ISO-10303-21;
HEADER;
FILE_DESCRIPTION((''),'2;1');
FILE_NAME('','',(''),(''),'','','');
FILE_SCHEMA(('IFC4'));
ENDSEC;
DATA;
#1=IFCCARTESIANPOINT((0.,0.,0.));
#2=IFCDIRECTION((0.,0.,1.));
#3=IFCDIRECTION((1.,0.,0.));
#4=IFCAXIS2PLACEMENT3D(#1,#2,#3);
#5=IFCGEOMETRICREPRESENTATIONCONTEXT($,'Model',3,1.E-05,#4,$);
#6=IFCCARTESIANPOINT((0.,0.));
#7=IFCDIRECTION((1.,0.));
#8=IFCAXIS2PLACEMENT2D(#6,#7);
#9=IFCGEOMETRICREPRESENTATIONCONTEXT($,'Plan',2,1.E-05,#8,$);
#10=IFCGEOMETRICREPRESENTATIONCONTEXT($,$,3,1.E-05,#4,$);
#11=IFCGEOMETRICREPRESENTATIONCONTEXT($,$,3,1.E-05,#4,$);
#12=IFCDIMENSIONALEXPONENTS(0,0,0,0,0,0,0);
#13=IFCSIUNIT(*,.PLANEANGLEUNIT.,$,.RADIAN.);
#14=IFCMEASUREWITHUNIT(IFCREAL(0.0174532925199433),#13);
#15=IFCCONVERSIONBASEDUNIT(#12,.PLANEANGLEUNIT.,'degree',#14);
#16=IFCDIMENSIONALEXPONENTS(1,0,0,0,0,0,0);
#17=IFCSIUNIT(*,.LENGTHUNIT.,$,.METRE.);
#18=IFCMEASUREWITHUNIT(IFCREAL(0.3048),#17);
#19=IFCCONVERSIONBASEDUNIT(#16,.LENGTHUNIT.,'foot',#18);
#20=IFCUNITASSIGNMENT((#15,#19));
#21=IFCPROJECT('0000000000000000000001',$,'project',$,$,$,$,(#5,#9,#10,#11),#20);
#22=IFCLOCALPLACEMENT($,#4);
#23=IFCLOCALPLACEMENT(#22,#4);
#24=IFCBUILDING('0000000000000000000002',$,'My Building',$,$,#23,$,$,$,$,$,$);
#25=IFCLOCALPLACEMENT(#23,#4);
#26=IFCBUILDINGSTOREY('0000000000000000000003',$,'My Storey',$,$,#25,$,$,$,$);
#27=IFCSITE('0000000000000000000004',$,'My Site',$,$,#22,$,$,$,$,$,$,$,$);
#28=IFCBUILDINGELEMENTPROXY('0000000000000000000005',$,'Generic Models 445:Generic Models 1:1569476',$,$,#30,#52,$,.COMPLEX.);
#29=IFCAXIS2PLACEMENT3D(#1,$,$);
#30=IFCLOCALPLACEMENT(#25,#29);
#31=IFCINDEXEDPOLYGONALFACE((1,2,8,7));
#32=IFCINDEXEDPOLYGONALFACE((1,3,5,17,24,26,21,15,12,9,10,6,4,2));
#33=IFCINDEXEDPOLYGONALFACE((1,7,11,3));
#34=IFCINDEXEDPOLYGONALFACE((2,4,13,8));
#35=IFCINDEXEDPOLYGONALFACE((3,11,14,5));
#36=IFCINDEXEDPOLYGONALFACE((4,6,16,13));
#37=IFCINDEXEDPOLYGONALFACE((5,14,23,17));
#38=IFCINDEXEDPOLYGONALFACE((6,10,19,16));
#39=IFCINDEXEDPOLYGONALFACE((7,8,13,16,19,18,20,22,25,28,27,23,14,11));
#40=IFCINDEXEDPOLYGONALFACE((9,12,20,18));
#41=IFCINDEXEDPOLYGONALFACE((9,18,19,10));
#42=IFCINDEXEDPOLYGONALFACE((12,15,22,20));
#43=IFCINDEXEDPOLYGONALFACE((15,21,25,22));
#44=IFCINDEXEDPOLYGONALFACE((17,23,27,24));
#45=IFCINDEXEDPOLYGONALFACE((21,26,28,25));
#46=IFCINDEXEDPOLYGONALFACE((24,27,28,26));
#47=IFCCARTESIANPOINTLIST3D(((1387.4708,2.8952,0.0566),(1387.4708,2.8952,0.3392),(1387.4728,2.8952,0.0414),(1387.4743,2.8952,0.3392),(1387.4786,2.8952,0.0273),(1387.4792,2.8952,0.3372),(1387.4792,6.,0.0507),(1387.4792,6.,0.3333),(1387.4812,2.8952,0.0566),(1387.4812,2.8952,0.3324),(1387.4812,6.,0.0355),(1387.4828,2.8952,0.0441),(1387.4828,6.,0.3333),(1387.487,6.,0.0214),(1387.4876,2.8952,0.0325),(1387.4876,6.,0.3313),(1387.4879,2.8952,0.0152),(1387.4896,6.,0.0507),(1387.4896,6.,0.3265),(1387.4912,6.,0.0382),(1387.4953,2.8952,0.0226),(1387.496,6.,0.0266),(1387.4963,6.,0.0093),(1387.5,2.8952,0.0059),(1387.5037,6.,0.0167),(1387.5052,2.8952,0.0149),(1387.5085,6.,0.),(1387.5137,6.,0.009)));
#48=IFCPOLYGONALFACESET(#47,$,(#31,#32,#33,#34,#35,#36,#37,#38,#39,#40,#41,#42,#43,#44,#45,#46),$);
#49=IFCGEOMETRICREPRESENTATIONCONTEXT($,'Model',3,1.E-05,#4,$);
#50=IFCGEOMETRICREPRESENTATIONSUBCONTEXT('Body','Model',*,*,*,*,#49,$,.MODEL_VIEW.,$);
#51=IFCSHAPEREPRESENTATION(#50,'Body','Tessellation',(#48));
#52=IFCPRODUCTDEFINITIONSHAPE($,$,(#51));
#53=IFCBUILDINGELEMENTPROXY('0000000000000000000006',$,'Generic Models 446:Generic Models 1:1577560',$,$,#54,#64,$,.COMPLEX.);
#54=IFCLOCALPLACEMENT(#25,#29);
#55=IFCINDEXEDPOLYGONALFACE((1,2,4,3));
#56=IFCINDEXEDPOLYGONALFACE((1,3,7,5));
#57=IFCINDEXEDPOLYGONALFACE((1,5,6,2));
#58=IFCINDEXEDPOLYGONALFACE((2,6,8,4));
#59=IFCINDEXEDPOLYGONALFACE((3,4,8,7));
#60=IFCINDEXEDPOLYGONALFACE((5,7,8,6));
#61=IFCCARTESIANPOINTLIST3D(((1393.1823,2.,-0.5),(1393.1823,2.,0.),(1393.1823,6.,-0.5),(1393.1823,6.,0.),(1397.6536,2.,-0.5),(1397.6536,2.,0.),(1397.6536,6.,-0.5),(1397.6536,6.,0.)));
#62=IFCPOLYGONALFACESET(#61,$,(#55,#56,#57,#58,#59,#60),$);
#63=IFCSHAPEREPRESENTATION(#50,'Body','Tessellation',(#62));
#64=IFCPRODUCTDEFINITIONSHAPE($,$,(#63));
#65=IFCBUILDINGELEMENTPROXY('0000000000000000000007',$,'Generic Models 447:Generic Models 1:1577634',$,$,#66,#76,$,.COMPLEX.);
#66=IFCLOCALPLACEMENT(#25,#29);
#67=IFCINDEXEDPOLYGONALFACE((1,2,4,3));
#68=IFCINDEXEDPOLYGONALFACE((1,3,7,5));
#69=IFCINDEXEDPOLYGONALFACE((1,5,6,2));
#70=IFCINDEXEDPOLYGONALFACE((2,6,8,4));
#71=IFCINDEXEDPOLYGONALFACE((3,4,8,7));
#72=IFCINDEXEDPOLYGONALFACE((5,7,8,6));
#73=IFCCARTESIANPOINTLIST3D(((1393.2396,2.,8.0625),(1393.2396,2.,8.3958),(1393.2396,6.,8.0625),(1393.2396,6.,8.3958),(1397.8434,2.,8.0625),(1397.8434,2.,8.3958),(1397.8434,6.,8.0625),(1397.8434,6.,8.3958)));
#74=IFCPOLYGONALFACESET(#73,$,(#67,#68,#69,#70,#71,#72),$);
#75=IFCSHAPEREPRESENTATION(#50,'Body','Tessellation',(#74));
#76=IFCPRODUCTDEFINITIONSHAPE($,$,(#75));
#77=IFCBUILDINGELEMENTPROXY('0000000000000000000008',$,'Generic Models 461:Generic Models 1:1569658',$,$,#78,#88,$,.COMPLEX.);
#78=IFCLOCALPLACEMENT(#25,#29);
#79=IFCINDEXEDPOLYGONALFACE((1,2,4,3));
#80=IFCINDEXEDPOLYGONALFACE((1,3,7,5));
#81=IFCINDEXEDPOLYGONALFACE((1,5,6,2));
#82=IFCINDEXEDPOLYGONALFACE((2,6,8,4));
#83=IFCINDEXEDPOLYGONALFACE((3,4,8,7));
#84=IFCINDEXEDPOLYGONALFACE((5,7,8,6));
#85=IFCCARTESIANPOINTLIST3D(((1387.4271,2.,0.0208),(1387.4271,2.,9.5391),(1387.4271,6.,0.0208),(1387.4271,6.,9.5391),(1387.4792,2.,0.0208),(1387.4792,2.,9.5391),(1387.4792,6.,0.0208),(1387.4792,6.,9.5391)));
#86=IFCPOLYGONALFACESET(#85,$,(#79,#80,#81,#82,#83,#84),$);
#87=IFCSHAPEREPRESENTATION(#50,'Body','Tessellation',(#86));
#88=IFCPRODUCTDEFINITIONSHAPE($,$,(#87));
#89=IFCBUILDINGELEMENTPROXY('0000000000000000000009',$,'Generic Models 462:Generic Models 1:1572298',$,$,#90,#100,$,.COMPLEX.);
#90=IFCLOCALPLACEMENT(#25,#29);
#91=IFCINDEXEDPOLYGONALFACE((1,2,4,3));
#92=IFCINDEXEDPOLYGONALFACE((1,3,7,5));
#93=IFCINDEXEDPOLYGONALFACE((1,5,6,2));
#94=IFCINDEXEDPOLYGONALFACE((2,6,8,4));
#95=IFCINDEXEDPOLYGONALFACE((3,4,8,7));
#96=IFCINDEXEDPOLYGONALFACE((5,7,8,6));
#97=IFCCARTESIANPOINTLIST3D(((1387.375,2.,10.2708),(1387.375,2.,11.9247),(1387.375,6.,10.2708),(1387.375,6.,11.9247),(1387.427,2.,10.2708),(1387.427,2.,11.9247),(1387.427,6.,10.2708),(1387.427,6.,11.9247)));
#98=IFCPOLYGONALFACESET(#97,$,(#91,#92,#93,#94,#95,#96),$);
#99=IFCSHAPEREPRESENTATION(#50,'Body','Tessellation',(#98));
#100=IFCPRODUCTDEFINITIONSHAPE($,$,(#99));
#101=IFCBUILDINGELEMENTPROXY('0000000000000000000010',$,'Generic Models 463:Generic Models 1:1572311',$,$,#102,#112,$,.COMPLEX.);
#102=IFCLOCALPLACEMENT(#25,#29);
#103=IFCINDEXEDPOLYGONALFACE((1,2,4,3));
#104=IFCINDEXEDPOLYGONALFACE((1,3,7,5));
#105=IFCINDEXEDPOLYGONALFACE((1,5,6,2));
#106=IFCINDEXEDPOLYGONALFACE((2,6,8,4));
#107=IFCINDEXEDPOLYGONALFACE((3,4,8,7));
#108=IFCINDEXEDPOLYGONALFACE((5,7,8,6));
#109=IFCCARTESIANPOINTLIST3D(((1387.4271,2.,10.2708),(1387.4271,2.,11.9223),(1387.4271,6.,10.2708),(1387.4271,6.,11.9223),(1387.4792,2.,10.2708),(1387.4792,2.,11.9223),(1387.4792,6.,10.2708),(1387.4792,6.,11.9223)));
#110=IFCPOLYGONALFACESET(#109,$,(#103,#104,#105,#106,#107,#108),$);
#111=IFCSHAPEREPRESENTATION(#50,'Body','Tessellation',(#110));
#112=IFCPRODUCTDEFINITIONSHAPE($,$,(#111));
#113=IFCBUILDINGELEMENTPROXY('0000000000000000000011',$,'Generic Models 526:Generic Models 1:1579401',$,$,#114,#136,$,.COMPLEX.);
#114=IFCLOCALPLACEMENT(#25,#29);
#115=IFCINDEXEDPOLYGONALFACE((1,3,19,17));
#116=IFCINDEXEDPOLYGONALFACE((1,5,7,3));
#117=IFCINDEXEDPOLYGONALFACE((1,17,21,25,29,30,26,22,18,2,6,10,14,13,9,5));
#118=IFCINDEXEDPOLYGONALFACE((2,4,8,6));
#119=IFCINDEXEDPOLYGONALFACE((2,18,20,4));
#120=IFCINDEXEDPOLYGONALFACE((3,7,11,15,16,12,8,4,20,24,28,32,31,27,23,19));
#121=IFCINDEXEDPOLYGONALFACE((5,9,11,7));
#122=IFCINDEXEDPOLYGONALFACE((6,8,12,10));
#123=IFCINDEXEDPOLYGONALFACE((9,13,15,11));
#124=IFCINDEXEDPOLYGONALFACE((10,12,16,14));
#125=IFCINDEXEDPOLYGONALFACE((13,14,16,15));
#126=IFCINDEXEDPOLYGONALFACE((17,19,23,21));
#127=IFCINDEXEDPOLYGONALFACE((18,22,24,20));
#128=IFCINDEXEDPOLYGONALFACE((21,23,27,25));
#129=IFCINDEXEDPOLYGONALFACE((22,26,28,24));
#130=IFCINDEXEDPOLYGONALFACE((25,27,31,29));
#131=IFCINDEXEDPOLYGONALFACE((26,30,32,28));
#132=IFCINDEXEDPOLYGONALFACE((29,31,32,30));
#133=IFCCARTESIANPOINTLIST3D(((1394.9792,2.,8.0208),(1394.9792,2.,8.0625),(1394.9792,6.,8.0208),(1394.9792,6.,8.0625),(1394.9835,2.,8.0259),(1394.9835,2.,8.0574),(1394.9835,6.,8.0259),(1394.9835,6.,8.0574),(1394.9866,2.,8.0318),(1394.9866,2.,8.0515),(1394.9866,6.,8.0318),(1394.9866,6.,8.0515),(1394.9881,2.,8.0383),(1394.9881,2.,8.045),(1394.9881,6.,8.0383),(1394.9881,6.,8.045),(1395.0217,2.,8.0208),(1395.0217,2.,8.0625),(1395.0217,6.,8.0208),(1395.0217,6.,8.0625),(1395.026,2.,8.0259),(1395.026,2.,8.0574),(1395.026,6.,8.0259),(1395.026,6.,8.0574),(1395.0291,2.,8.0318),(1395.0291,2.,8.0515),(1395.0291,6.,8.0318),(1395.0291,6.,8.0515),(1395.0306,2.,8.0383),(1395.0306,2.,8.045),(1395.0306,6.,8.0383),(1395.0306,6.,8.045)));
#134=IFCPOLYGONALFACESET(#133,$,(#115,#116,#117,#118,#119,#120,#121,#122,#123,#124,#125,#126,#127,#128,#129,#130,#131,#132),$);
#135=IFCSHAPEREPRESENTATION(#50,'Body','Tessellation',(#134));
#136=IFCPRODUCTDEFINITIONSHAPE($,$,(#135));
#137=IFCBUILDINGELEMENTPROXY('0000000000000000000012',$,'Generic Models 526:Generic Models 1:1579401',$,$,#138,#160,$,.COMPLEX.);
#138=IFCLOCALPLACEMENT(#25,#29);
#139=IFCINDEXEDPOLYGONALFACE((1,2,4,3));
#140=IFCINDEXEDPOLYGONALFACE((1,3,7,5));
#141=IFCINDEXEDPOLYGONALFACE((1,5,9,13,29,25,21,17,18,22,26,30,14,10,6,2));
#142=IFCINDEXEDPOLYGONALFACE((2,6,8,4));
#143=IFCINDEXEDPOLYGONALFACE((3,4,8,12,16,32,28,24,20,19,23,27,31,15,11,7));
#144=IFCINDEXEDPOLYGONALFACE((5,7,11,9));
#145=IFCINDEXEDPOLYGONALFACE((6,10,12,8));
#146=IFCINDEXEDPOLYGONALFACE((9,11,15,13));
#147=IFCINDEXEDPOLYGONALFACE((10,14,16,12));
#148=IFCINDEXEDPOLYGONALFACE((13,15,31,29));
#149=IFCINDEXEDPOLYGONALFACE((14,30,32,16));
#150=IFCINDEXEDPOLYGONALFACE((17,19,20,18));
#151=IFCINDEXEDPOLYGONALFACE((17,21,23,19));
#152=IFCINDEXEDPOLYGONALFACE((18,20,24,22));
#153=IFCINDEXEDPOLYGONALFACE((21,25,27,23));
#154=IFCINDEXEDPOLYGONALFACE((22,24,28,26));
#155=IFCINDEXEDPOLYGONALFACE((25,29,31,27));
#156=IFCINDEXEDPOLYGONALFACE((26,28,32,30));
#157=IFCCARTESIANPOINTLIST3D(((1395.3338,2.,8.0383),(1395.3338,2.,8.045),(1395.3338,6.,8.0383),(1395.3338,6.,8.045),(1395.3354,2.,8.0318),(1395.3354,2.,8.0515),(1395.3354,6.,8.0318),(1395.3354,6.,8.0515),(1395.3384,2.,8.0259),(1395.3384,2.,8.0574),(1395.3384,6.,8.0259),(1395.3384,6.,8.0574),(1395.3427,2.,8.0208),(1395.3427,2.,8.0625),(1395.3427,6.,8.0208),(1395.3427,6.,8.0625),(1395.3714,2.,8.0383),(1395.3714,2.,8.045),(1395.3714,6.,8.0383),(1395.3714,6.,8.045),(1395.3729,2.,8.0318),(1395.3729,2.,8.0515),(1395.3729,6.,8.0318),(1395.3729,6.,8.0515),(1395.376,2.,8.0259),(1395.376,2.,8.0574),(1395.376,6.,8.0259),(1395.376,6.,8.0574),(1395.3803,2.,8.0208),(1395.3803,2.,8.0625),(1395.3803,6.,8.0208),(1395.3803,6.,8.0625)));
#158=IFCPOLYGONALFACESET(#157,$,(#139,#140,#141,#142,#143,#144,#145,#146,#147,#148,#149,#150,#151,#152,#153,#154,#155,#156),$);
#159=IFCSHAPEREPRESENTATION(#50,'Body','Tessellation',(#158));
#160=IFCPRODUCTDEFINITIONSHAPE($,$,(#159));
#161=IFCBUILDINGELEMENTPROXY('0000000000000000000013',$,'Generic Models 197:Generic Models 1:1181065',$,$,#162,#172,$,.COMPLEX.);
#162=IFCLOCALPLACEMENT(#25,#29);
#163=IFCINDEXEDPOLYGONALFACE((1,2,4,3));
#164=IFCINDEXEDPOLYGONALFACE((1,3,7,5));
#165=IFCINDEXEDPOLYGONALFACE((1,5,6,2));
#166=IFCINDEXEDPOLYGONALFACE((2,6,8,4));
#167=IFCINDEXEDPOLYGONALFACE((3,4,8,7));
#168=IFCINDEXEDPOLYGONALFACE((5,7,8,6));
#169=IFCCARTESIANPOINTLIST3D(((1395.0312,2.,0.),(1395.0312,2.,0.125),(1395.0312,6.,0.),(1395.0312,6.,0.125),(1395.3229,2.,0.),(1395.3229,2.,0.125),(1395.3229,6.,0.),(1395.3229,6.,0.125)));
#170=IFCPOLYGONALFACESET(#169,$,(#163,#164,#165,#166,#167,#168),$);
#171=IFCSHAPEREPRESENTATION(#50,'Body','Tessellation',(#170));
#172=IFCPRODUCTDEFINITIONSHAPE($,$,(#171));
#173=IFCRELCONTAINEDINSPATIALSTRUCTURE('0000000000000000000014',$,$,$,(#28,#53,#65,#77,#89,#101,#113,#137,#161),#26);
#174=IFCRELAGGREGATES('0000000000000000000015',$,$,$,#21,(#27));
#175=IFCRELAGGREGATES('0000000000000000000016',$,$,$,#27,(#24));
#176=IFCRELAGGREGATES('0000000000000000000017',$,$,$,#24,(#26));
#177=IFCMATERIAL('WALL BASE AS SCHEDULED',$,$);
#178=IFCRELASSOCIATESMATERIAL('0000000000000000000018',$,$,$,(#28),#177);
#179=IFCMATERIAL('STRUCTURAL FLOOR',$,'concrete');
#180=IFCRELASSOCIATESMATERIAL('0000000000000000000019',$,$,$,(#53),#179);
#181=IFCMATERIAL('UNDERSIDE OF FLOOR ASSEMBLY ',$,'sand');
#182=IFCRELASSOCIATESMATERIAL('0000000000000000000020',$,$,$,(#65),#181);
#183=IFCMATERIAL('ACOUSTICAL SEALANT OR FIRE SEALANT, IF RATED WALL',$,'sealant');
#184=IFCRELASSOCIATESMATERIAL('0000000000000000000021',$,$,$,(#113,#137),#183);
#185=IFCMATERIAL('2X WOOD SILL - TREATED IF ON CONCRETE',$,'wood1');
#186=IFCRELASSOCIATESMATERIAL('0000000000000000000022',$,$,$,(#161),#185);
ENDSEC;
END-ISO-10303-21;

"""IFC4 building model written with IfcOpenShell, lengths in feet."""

from ifc_helpers import new_model, entity, si_unit, converted_unit, frame, origin_with_axes, origin_2d_with_axis, place, context, subcontext, project, spatial, polyline, line, indexed_curve, outline, extrude, material, element, save


model = new_model("IFC4")

# Units and contexts
model_context_1 = context("Model", 3, precision=1e-05, world=origin_with_axes())
plan_context = context("Plan", 2, precision=1e-05, world=origin_2d_with_axis())
model_context_2 = context("Model", 3, precision=1e-05, world=origin_with_axes())
context_of_model_1 = context(None, 3, precision=1e-05, world=origin_with_axes())
context_of_model_2 = context(None, 3, precision=1e-05, world=origin_with_axes())
body_context_1 = subcontext(model_context_2, "Body", "Model", "MODEL_VIEW")
ifc_project = project(units=[converted_unit("PLANEANGLEUNIT", "degree", entity("IfcReal", 0.0174532925199433), si_unit("PLANEANGLEUNIT", "RADIAN"), dimensions=[0, 0, 0, 0, 0, 0, 0]), converted_unit("LENGTHUNIT", "foot", entity("IfcReal", 0.3048), si_unit("LENGTHUNIT", "METRE"), dimensions=[1, 0, 0, 0, 0, 0, 0])], contexts=[model_context_1, plan_context, context_of_model_1, context_of_model_2])

# Site, building, storey
site_placement = place(None, origin_with_axes())
site = spatial("IfcSite", under=ifc_project, at=site_placement, Name="My Site")
building_placement = place(site_placement, origin_with_axes())
building = spatial("IfcBuilding", under=site, at=building_placement, Name="My Building")
storey_placement = place(building_placement, origin_with_axes())
storey = spatial("IfcBuildingStorey", under=building, at=storey_placement, Name="My Storey")

# Building element proxies
ifc_material_1 = material(Name="WALL BASE AS SCHEDULED")
ifc_material_2 = material(Name="STRUCTURAL FLOOR", Category="concrete")
ifc_material_3 = material(Name="UNDERSIDE OF FLOOR ASSEMBLY ", Category="sand")
ifc_material_4 = material(Name="ACOUSTICAL SEALANT OR FIRE SEALANT, IF RATED WALL", Category="sealant")
proxy_1_placement = place(storey_placement, frame((1387.4792, 6.0, 0.0), z_axis=(0.0, -1.0, 0.0), x_axis=(0.0, 0.0, 1.0)))
element("IfcBuildingElementProxy", 1, at=proxy_1_placement, inside=storey, material=ifc_material_1, Name="Generic Models 445:Generic Models 1:1569476", PredefinedType="COMPLEX", context=body_context_1, shape_type="SweptSolid", body=[
    extrude(outline(polyline([(0.2206, 0.0), (0.2204, 0.0036), (0.2182, 0.0083), (0.2132, 0.01), (-0.0621, -0.0058), (-0.0747, -0.0049), (-0.0865, -0.0007), (-0.0969, 0.0063), (-0.1051, 0.0158), (-0.1138, 0.0101), (-0.1038, -0.0014), (-0.0912, -0.01), (-0.0768, -0.0151), (-0.0615, -0.0162), (0.2206, 0.0)])), frame((0.113, -0.0126, 0.0), z_axis=(0.0, 0.0, -1.0), x_axis=(0.998358, 0.057286, 0.0)), (0.002054, -0.002598, -0.999995), 3.1048),
])
proxy_2_placement = place(storey_placement, frame((1393.1823, 6.0, -0.5), z_axis=(0.0, -1.0, 0.0), x_axis=(0.0, 0.0, 1.0)))
element("IfcBuildingElementProxy", 2, at=proxy_2_placement, inside=storey, material=ifc_material_2, Name="Generic Models 446:Generic Models 1:1577560", PredefinedType="COMPLEX", context=body_context_1, shape_type="SweptSolid", body=[
    extrude(outline(indexed_curve([(-2.4713, -0.25), (2.0, -0.25), (2.0, 0.25), (-2.4713, 0.25)], segments=[line(4, 1), line(1, 2), line(2, 3), line(3, 4)], self_intersect=False)), frame((0.25, -2.0, 0.0), z_axis=(0.0, 0.0, -1.0), x_axis=(0.0, 1.0, 0.0)), (0.0, 0.0, -1.0), 4.0),
])
proxy_3_placement = place(storey_placement, frame((1393.2396, 6.0, 8.0625), z_axis=(0.0, -1.0, 0.0), x_axis=(0.0, 0.0, 1.0)))
element("IfcBuildingElementProxy", 3, at=proxy_3_placement, inside=storey, material=ifc_material_3, Name="Generic Models 447:Generic Models 1:1577634", PredefinedType="COMPLEX", context=body_context_1, shape_type="SweptSolid", body=[
    extrude(outline(indexed_curve([(2.0, -0.1667), (2.0, 0.1667), (-2.6038, 0.1667), (-2.6038, -0.1667)], segments=[line(3, 2), line(2, 1), line(1, 4), line(4, 3)], self_intersect=False)), frame((0.1667, -2.0, 0.0), z_axis=(0.0, 0.0, -1.0), x_axis=(0.0, 1.0, 0.0)), (0.0, 0.0, -1.0), 4.0),
])
proxy_4_placement = place(storey_placement, frame((1387.4271, 6.0, 0.0208), z_axis=(0.0, -1.0, 0.0), x_axis=(0.0, 0.0, 1.0)))
element("IfcBuildingElementProxy", 4, at=proxy_4_placement, inside=storey, Name="Generic Models 461:Generic Models 1:1569658", PredefinedType="COMPLEX", context=body_context_1, shape_type="SweptSolid", body=[
    extrude(outline(polyline([(-4.7591, -0.026), (4.7591, -0.026), (4.7591, 0.026), (-4.7591, 0.026), (-4.7591, -0.026)])), frame((4.7591, -0.026, 0.0), z_axis=(0.0, 0.0, -1.0), x_axis=(-1.0, 0.0, 0.0)), (0.0, 0.0, -1.0), 4.0),
])
proxy_5_placement = place(storey_placement, frame((1387.375, 6.0, 10.2708), z_axis=(0.0, -1.0, 0.0), x_axis=(0.0, 0.0, 1.0)))
element("IfcBuildingElementProxy", 5, at=proxy_5_placement, inside=storey, Name="Generic Models 462:Generic Models 1:1572298", PredefinedType="COMPLEX", context=body_context_1, shape_type="SweptSolid", body=[
    extrude(outline(polyline([(-0.026, -0.8269), (0.026, -0.8269), (0.026, 0.8269), (-0.026, 0.8269), (-0.026, -0.8269)])), frame((0.8269, -0.026, 0.0), z_axis=(0.0, 0.0, -1.0), x_axis=(0.0, 1.0, 0.0)), (0.0, 0.0, -1.0), 4.0),
])
proxy_6_placement = place(storey_placement, frame((1387.4271, 6.0, 10.2708), z_axis=(0.0, -1.0, 0.0), x_axis=(0.0, 0.0, 1.0)))
element("IfcBuildingElementProxy", 6, at=proxy_6_placement, inside=storey, Name="Generic Models 463:Generic Models 1:1572311", PredefinedType="COMPLEX", context=body_context_1, shape_type="SweptSolid", body=[
    extrude(outline(polyline([(-0.026, -0.8258), (0.026, -0.8258), (0.026, 0.8258), (-0.026, 0.8258), (-0.026, -0.8258)])), frame((0.8258, -0.026, 0.0), z_axis=(0.0, 0.0, -1.0), x_axis=(0.0, 1.0, 0.0)), (0.0, 0.0, -1.0), 4.0),
])
proxy_7_placement = place(storey_placement, frame((1394.9791, 6.0, 8.0208), z_axis=(0.0, -1.0, 0.0), x_axis=(0.0, 0.0, 1.0)))
element("IfcBuildingElementProxy", 7, at=proxy_7_placement, inside=storey, material=ifc_material_4, Name="Generic Models 526:Generic Models 1:1579401", PredefinedType="COMPLEX", context=body_context_1, shape_type="SweptSolid", body=[
    extrude(outline(indexed_curve([(0.0293, -0.0082), (0.0301, -0.0016), (0.001, 0.0294), (0.0002, 0.0228), (-0.002, 0.0165), (-0.0057, 0.0109), (-0.0105, 0.0064), (-0.0163, 0.0031), (-0.0228, 0.0012), (-0.0294, 0.0009), (-0.0003, -0.0301), (0.0063, -0.0298), (0.0128, -0.028), (0.0186, -0.0247), (0.0234, -0.0201), (0.0271, -0.0145)], segments=[line(2, 1), line(1, 16), line(16, 15), line(15, 14), line(14, 13), line(13, 12), line(12, 11), line(11, 10), line(10, 9), line(9, 8), line(8, 7), line(7, 6), line(6, 5), line(5, 4), line(4, 3), line(3, 2)], self_intersect=False)), frame((0.0208, -0.0208, 0.0), z_axis=(0.0, 0.0, -1.0), x_axis=(-0.729168, -0.684334, 0.0)), (0.0, 0.0, -1.0), 4.0),
])
proxy_8_placement = place(storey_placement, frame((1395.3854, 6.0, 8.0625), z_axis=(0.0, -1.0, 0.0), x_axis=(0.0, 0.0, -1.0)))
element("IfcBuildingElementProxy", 8, at=proxy_8_placement, inside=storey, material=ifc_material_4, Name="Generic Models 526:Generic Models 1:1579401", PredefinedType="COMPLEX", context=body_context_1, shape_type="SweptSolid", body=[
    extrude(outline(indexed_curve([(-0.0193, -0.0025), (-0.0129, -0.0006), (-0.0071, 0.0027), (-0.0022, 0.0072), (0.0014, 0.0128), (0.0037, 0.0191), (0.0044, 0.0258), (0.0301, -0.0017), (0.0294, -0.0083), (0.0272, -0.0146), (0.0235, -0.0202), (0.0186, -0.0247), (0.0128, -0.028), (0.0064, -0.0299), (-0.0002, -0.0302), (-0.026, -0.0028)], segments=[line(2, 1), line(1, 16), line(16, 15), line(15, 14), line(14, 13), line(13, 12), line(12, 11), line(11, 10), line(10, 9), line(9, 8), line(8, 7), line(7, 6), line(6, 5), line(5, 4), line(4, 3), line(3, 2)], self_intersect=False)), frame((0.0208, -0.0208, 0.0), z_axis=(0.0, 0.0, -1.0), x_axis=(-0.729168, -0.684334, 0.0)), (0.0, 0.0, -1.0), 4.0),
])
ifc_material_5 = material(Name="2X WOOD SILL - TREATED IF ON CONCRETE", Category="wood1")
proxy_9_placement = place(storey_placement, frame((1395.0312, 6.0, 0.125), z_axis=(0.0, -1.0, 0.0), x_axis=(1.0, 0.0, 0.0)))
element("IfcBuildingElementProxy", 9, at=proxy_9_placement, inside=storey, material=ifc_material_5, Name="Generic Models 197:Generic Models 1:1181065", PredefinedType="COMPLEX", context=body_context_1, shape_type="SweptSolid", body=[
    extrude(outline(polyline([(-0.0625, -0.1458), (0.0625, -0.1458), (0.0625, 0.1458), (-0.0625, 0.1458), (-0.0625, -0.1458)])), frame((0.1458, -0.0625, 0.0), z_axis=(0.0, 0.0, -1.0), x_axis=(0.0, 1.0, 0.0)), (0.0, 0.0, -1.0), 4.0),
])

save(model, "model.ifc")
